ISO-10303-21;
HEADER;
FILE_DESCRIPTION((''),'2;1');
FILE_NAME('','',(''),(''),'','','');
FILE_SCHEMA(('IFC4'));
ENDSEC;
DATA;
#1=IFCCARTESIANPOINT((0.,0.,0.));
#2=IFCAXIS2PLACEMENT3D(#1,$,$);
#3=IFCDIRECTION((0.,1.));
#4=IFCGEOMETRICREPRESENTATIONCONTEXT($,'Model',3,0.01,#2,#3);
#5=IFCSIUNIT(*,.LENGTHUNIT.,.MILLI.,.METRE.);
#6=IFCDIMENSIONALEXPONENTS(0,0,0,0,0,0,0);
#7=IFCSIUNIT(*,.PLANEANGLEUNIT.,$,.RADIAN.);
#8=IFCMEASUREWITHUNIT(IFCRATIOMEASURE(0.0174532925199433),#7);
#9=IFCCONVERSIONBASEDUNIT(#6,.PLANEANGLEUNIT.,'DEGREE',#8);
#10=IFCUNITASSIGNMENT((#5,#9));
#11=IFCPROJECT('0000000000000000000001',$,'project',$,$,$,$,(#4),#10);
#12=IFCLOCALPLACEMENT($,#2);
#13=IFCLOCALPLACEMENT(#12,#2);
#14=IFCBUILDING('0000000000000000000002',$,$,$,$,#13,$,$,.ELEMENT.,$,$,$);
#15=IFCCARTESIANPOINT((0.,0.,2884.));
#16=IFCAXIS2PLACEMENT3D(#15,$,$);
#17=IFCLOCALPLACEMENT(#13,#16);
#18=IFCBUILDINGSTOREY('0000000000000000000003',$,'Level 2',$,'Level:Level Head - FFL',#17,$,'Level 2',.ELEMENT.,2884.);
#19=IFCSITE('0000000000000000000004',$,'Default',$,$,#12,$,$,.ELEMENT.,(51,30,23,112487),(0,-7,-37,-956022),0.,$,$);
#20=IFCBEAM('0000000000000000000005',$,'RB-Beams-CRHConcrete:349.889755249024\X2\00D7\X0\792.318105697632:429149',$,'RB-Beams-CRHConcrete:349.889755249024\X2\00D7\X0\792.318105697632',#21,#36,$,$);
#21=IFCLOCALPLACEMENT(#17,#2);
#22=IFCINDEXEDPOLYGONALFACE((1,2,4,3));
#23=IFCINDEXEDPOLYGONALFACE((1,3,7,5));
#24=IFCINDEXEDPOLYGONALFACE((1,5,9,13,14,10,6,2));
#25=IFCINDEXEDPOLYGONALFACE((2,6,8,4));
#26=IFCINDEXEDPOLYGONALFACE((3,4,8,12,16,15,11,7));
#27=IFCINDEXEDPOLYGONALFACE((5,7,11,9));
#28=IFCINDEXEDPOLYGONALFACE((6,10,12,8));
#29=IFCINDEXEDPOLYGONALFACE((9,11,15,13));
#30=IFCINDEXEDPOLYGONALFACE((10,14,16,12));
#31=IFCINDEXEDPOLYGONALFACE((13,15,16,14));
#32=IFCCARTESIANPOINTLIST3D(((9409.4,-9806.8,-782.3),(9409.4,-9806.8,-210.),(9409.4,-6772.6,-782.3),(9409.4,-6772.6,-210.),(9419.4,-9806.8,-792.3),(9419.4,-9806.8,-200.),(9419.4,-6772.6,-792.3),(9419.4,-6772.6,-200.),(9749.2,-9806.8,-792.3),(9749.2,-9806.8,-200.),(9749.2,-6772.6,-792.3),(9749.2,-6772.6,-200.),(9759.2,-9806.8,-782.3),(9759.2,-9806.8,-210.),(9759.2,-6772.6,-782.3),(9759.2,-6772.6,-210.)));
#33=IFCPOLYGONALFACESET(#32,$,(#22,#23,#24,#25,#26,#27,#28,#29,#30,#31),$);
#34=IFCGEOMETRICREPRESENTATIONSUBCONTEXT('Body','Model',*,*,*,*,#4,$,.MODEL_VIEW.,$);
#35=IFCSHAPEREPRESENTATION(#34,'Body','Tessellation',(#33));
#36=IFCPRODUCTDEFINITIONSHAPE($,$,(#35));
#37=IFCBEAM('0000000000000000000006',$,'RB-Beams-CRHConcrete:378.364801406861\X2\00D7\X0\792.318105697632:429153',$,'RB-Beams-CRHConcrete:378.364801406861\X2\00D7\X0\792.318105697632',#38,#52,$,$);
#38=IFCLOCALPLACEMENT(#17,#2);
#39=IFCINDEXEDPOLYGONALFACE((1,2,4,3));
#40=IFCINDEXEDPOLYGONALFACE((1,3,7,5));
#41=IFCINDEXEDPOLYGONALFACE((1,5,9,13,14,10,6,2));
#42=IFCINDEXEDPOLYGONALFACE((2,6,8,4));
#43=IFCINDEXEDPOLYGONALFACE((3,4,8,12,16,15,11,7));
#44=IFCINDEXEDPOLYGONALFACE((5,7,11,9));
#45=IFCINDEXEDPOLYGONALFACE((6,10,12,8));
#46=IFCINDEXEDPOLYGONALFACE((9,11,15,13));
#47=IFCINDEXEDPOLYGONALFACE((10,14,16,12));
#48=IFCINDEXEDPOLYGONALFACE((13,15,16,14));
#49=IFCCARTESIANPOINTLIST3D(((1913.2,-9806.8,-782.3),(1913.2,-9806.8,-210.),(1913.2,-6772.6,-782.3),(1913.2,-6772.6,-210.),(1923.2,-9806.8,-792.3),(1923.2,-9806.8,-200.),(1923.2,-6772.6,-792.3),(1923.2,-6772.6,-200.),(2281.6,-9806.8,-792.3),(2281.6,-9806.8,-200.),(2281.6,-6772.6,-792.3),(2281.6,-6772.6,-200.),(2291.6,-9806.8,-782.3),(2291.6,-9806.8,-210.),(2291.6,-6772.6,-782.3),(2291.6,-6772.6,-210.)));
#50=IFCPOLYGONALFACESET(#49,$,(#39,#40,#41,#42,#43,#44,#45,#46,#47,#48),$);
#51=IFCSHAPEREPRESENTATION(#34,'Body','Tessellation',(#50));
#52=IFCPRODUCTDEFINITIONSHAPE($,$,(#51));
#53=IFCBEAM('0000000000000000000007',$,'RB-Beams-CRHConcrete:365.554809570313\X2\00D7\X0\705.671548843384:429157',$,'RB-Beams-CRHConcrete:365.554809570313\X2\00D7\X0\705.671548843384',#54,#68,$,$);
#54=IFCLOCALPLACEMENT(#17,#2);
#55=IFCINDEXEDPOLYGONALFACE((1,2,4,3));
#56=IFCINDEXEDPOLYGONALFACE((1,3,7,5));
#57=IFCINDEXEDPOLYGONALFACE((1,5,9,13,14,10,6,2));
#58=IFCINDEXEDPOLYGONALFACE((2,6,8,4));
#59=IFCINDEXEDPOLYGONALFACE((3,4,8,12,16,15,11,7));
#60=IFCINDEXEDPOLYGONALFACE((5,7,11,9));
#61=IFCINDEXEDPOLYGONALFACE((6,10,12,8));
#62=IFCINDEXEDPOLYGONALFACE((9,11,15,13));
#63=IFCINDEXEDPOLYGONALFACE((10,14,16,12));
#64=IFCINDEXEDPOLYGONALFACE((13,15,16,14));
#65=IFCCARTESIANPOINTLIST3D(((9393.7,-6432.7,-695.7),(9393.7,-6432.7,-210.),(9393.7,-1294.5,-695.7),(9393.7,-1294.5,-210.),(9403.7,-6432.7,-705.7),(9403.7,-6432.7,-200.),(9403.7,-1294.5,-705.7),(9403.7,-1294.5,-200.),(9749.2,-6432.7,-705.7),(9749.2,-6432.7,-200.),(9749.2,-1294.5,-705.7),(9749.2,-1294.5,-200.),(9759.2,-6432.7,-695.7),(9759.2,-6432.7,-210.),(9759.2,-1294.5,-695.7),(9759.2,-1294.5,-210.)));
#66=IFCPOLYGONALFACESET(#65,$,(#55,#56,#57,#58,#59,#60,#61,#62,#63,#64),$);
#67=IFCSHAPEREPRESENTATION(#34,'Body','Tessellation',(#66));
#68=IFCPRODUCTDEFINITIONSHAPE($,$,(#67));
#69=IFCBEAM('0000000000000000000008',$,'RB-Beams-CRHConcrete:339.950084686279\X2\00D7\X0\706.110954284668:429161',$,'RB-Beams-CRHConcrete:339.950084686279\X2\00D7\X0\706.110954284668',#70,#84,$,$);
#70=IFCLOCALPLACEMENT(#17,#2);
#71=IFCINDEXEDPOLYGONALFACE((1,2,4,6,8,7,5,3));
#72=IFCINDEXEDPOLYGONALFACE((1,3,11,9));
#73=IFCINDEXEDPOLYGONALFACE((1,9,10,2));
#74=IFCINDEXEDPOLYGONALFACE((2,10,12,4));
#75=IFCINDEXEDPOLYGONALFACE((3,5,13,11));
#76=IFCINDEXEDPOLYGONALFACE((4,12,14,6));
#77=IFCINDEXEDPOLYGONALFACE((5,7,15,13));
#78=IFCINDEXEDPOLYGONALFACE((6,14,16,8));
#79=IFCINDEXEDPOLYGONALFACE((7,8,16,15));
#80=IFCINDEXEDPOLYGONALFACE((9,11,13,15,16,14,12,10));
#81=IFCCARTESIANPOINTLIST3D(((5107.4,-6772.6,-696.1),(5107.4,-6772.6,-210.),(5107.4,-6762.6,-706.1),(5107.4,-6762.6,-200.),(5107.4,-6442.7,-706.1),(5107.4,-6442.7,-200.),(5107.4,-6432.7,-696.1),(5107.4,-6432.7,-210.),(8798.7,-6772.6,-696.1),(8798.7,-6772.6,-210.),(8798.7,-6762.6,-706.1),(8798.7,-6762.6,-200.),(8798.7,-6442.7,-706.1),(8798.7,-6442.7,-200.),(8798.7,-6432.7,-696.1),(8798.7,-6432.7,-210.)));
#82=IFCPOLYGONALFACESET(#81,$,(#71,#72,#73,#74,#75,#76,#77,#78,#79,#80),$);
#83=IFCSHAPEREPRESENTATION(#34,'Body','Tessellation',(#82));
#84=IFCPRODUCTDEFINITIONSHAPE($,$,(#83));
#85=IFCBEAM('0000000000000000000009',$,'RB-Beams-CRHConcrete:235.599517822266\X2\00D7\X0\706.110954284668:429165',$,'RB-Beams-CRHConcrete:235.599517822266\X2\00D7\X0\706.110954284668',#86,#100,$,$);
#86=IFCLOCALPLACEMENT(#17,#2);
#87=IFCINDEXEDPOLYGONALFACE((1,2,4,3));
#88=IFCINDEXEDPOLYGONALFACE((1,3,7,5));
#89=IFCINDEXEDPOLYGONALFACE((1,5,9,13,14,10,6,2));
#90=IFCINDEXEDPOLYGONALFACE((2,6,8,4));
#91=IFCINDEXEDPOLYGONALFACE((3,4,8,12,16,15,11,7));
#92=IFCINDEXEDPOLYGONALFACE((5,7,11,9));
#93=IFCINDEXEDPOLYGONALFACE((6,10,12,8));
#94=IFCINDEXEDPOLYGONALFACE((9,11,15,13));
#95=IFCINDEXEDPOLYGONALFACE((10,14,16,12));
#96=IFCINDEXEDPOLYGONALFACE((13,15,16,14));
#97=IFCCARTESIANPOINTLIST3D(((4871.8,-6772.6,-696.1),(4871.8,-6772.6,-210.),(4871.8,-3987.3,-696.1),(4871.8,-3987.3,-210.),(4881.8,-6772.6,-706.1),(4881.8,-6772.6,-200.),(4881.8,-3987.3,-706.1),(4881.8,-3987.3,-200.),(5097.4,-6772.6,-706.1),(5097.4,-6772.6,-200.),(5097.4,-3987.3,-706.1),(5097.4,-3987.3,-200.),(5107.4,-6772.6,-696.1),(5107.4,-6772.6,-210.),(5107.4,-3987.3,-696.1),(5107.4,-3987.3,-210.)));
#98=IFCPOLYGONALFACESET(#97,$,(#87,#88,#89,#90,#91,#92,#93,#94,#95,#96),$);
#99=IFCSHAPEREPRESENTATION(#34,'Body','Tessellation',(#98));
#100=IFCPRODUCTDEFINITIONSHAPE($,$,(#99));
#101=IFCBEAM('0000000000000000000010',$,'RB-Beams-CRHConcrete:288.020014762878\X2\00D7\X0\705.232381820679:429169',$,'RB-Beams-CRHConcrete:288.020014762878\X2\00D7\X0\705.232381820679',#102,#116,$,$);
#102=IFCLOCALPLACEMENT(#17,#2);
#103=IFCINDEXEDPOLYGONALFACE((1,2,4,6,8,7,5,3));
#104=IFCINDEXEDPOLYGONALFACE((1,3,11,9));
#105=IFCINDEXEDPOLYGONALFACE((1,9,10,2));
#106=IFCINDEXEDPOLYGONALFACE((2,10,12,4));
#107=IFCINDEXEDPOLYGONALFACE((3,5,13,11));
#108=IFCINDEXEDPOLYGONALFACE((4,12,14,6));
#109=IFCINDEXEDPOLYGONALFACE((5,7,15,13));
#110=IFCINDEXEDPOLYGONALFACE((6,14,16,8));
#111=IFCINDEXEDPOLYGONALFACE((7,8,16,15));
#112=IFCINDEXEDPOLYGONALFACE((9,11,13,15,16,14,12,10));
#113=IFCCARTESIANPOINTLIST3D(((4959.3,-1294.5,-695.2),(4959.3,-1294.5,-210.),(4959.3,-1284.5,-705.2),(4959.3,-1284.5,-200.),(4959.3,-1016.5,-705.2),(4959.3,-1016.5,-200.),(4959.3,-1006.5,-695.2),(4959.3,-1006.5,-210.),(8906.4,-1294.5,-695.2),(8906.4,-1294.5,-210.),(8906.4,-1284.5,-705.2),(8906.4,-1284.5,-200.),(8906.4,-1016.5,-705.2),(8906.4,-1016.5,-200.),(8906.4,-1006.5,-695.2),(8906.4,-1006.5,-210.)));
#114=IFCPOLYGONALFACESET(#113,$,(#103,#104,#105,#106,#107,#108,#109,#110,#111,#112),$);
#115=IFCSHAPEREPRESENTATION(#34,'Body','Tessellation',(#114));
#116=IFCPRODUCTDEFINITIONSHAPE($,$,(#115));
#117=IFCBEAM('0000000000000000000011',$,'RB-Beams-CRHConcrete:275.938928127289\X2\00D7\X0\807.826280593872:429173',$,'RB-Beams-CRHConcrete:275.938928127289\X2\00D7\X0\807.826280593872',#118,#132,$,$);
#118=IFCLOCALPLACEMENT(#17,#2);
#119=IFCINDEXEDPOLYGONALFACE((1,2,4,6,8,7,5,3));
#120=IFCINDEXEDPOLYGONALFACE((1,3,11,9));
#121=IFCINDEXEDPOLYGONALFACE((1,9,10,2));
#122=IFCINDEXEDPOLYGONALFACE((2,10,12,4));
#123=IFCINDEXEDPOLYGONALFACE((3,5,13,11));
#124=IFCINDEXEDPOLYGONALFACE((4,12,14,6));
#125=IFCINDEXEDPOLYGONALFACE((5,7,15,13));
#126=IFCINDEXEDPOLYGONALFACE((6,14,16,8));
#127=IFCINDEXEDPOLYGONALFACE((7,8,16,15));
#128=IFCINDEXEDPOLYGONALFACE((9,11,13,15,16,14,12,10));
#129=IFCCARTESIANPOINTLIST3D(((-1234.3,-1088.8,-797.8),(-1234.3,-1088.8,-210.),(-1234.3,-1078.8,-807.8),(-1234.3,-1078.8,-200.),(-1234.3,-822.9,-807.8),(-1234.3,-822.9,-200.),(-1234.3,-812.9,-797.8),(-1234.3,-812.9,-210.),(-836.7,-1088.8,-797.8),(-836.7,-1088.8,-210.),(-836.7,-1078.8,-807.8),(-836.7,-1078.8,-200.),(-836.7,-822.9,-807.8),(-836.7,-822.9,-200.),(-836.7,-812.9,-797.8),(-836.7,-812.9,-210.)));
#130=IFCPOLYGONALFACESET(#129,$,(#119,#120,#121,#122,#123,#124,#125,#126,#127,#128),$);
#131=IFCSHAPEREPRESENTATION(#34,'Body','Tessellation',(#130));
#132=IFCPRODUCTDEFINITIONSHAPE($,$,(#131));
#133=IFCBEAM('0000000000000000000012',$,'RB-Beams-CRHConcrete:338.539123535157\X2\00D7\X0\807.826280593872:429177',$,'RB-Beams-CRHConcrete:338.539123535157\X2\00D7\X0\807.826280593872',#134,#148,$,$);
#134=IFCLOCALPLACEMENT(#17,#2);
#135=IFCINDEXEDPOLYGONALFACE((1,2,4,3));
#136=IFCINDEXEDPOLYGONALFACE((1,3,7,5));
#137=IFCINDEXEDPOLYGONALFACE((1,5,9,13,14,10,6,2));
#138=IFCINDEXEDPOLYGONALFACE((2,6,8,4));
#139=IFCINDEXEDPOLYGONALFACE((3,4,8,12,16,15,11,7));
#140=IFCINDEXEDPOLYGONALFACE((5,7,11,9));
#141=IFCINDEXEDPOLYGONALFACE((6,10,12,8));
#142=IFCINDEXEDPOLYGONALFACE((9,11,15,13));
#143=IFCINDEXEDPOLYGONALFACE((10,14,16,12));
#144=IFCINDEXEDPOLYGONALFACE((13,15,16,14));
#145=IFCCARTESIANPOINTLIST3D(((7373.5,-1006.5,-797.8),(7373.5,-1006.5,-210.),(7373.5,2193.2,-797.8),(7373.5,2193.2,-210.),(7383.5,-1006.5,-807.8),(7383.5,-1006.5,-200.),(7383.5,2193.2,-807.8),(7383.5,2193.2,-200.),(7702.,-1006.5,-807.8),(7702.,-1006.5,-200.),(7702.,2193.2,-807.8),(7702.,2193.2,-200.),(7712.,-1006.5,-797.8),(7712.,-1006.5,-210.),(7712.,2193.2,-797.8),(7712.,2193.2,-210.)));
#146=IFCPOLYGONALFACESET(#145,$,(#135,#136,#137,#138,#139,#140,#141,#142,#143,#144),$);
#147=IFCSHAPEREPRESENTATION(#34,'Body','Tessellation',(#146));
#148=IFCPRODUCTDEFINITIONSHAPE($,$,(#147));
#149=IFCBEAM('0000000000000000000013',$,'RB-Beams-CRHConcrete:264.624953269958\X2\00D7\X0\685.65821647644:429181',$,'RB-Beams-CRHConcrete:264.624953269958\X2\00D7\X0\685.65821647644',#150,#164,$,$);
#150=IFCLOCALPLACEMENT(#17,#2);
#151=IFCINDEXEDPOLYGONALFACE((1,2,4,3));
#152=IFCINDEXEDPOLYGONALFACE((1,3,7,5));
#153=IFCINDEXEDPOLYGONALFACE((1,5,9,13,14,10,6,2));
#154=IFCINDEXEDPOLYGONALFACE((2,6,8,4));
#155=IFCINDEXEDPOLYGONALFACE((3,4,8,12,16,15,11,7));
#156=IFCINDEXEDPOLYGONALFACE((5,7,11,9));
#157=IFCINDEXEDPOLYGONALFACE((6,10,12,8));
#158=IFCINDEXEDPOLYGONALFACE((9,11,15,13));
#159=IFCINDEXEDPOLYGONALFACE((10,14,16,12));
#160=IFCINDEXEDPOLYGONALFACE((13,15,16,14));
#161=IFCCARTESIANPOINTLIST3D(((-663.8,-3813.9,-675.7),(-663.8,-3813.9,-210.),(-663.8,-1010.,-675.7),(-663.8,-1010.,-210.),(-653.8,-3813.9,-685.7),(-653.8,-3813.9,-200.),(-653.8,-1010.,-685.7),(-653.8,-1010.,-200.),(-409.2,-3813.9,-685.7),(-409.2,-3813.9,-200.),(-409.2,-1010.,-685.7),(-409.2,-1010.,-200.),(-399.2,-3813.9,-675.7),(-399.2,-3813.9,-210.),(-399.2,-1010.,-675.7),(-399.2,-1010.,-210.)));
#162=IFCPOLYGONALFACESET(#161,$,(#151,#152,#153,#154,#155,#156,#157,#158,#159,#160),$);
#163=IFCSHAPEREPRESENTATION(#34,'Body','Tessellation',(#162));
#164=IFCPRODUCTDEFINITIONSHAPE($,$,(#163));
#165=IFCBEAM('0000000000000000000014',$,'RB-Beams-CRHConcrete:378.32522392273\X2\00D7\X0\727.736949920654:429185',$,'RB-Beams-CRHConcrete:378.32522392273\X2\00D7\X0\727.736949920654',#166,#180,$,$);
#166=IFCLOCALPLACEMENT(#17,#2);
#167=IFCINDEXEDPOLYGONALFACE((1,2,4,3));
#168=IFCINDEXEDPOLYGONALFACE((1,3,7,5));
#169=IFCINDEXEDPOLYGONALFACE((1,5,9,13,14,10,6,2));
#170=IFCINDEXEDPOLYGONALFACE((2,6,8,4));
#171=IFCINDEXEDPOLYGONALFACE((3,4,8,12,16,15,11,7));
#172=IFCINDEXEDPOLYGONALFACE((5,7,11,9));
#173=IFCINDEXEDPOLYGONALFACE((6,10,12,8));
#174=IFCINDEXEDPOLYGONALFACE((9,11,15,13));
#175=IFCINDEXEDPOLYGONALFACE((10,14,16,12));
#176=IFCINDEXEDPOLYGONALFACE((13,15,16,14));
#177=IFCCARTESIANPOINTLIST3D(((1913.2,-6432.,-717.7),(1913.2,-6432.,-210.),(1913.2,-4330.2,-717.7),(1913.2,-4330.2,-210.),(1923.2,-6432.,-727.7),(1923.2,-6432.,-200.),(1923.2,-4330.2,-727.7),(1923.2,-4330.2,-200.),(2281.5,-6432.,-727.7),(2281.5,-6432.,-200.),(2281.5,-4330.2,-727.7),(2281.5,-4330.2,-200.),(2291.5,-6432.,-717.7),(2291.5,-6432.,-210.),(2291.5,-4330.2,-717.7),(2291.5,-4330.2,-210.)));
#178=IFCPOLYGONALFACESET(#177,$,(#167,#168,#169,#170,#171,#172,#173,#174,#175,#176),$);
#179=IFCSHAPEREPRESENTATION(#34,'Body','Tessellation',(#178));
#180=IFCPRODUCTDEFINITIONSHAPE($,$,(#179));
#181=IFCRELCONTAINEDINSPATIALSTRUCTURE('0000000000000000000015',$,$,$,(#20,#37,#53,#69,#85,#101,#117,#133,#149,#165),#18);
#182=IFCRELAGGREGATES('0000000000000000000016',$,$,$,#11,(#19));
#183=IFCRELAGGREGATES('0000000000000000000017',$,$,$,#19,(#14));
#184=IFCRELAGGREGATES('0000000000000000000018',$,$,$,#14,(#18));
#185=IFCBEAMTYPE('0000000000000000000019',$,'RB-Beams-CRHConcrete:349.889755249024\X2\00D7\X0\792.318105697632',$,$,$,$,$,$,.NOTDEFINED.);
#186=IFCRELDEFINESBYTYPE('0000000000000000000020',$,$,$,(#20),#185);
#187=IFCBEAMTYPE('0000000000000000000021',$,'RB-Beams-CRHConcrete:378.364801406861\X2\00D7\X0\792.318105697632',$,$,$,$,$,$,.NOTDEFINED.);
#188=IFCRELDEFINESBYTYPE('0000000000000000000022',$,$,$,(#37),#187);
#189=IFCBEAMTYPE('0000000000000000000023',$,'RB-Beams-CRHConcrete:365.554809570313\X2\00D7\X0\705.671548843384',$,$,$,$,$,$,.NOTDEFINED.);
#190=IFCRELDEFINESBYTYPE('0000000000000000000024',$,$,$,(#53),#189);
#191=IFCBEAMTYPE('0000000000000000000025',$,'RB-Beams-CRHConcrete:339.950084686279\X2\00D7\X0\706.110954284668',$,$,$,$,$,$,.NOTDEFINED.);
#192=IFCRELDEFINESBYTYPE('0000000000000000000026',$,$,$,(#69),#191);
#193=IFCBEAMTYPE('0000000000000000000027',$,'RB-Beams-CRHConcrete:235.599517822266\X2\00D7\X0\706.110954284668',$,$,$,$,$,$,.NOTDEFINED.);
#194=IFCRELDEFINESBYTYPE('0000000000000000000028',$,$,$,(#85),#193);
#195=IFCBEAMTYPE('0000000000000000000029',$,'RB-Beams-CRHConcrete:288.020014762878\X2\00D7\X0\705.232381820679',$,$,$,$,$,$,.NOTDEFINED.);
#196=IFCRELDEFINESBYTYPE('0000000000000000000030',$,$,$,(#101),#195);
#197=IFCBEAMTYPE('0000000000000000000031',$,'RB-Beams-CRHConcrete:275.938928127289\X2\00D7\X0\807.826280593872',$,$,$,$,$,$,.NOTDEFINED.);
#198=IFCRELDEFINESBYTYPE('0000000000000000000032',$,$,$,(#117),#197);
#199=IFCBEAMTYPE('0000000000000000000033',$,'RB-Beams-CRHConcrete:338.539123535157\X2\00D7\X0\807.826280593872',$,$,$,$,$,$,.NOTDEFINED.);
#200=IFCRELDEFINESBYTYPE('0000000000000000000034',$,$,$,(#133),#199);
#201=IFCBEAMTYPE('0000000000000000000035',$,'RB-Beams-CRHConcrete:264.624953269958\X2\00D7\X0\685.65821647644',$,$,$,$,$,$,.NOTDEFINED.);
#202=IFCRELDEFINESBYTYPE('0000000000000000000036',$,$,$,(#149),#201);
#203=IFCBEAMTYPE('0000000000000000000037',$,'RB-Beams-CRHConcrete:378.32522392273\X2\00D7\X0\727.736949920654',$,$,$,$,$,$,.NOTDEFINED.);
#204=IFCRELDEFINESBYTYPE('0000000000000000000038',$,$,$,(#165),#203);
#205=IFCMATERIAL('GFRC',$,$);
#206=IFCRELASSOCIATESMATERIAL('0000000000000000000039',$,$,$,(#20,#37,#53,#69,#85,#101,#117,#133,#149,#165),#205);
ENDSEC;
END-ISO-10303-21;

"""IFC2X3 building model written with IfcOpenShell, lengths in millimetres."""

from ifc_helpers import new_model, entity, si_unit, converted_unit, direction, frame, origin, place, context, subcontext, project, spatial, polyline, outline, extrude, material, type_object, element, save


model = new_model("IFC2X3")

# Units and contexts
model_context = context("Model", 3, precision=0.01, world=origin(), true_north=direction((0.0, 1.0)))
body_context = subcontext(model_context, "Body", "Model", "MODEL_VIEW")
ifc_project = project(units=[si_unit("LENGTHUNIT", "METRE", prefix="MILLI"), converted_unit("PLANEANGLEUNIT", "DEGREE", entity("IfcRatioMeasure", 0.0174532925199433), si_unit("PLANEANGLEUNIT", "RADIAN"), dimensions=[0, 0, 0, 0, 0, 0, 0])], contexts=[model_context])

# Site, building, storey
site_placement = place(None, origin())
site = spatial("IfcSite", under=ifc_project, at=site_placement, Name="Default", CompositionType="ELEMENT", RefLatitude=(51, 30, 23, 112487), RefLongitude=(0, -7, -37, -956022), RefElevation=0.0)
building_placement = place(site_placement, origin())
building = spatial("IfcBuilding", under=site, at=building_placement, CompositionType="ELEMENT")
storey_placement = place(building_placement, frame((0.0, 0.0, 2884.0)))
storey = spatial("IfcBuildingStorey", under=building, at=storey_placement, Name="Level 2", ObjectType="Level:Level Head - FFL", LongName="Level 2", CompositionType="ELEMENT", Elevation=2884.0)

# Beams
ifc_material_1 = material(Name="GFRC")
beam_type_1 = type_object("IfcBeamType", Name="RB-Beams-CRHConcrete:349.889755249024×792.318105697632", PredefinedType="NOTDEFINED")
beam_1_placement = place(storey_placement, frame((9584.3, -9806.8, -200.0), z_axis=(0.0, 0.0, 1.0), x_axis=(0.0, 1.0, 0.0)))
element("IfcBeam", 1, at=beam_1_placement, inside=storey, type_object=beam_type_1, material=ifc_material_1, Name="RB-Beams-CRHConcrete:349.889755249024×792.318105697632:429149", ObjectType="RB-Beams-CRHConcrete:349.889755249024×792.318105697632", context=body_context, shape_type="SweptSolid", body=[
    extrude(outline(polyline([(-286.2, -174.9), (286.2, -174.9), (296.2, -164.9), (296.2, 164.9), (286.2, 174.9), (-286.2, 174.9), (-296.2, 164.9), (-296.2, -164.9), (-286.2, -174.9)])), frame((0.0, 0.0, -296.2), z_axis=(1.0, 0.0, 0.0), x_axis=(0.0, 0.0, -1.0)), (0.0, 0.0, 1.0), 3034.2),
])
beam_type_2 = type_object("IfcBeamType", Name="RB-Beams-CRHConcrete:378.364801406861×792.318105697632", PredefinedType="NOTDEFINED")
beam_2_placement = place(storey_placement, frame((2102.4, -9806.8, -200.0), z_axis=(0.0, 0.0, 1.0), x_axis=(0.0, 1.0, 0.0)))
element("IfcBeam", 2, at=beam_2_placement, inside=storey, type_object=beam_type_2, material=ifc_material_1, Name="RB-Beams-CRHConcrete:378.364801406861×792.318105697632:429153", ObjectType="RB-Beams-CRHConcrete:378.364801406861×792.318105697632", context=body_context, shape_type="SweptSolid", body=[
    extrude(outline(polyline([(-286.2, -189.2), (286.2, -189.2), (296.2, -179.2), (296.2, 179.2), (286.2, 189.2), (-286.2, 189.2), (-296.2, 179.2), (-296.2, -179.2), (-286.2, -189.2)])), frame((0.0, 0.0, -296.2), z_axis=(1.0, 0.0, 0.0), x_axis=(0.0, 0.0, -1.0)), (0.0, 0.0, 1.0), 3034.2),
])
beam_type_3 = type_object("IfcBeamType", Name="RB-Beams-CRHConcrete:365.554809570313×705.671548843384", PredefinedType="NOTDEFINED")
beam_3_placement = place(storey_placement, frame((9576.5, -6432.7, -200.0), z_axis=(0.0, 0.0, 1.0), x_axis=(0.0, 1.0, 0.0)))
element("IfcBeam", 3, at=beam_3_placement, inside=storey, type_object=beam_type_3, material=ifc_material_1, Name="RB-Beams-CRHConcrete:365.554809570313×705.671548843384:429157", ObjectType="RB-Beams-CRHConcrete:365.554809570313×705.671548843384", context=body_context, shape_type="SweptSolid", body=[
    extrude(outline(polyline([(-242.8, -182.8), (242.8, -182.8), (252.8, -172.8), (252.8, 172.8), (242.8, 182.8), (-242.8, 182.8), (-252.8, 172.8), (-252.8, -172.8), (-242.8, -182.8)])), frame((0.0, 0.0, -252.8), z_axis=(1.0, 0.0, 0.0), x_axis=(0.0, 0.0, -1.0)), (0.0, 0.0, 1.0), 5138.2),
])
beam_type_4 = type_object("IfcBeamType", Name="RB-Beams-CRHConcrete:339.950084686279×706.110954284668", PredefinedType="NOTDEFINED")
beam_4_placement = place(storey_placement, frame((5107.4, -6602.7, -200.0)))
element("IfcBeam", 4, at=beam_4_placement, inside=storey, type_object=beam_type_4, material=ifc_material_1, Name="RB-Beams-CRHConcrete:339.950084686279×706.110954284668:429161", ObjectType="RB-Beams-CRHConcrete:339.950084686279×706.110954284668", context=body_context, shape_type="SweptSolid", body=[
    extrude(outline(polyline([(-243.1, -170.0), (243.1, -170.0), (253.1, -160.0), (253.1, 160.0), (243.1, 170.0), (-243.1, 170.0), (-253.1, 160.0), (-253.1, -160.0), (-243.1, -170.0)])), frame((0.0, 0.0, -253.1), z_axis=(1.0, 0.0, 0.0), x_axis=(0.0, 0.0, -1.0)), (0.0, 0.0, 1.0), 3691.3),
])
beam_type_5 = type_object("IfcBeamType", Name="RB-Beams-CRHConcrete:235.599517822266×706.110954284668", PredefinedType="NOTDEFINED")
beam_5_placement = place(storey_placement, frame((4989.6, -6772.6, -200.0), z_axis=(0.0, 0.0, 1.0), x_axis=(0.0, 1.0, 0.0)))
element("IfcBeam", 5, at=beam_5_placement, inside=storey, type_object=beam_type_5, material=ifc_material_1, Name="RB-Beams-CRHConcrete:235.599517822266×706.110954284668:429165", ObjectType="RB-Beams-CRHConcrete:235.599517822266×706.110954284668", context=body_context, shape_type="SweptSolid", body=[
    extrude(outline(polyline([(-243.1, -117.8), (243.1, -117.8), (253.1, -107.8), (253.1, 107.8), (243.1, 117.8), (-243.1, 117.8), (-253.1, 107.8), (-253.1, -107.8), (-243.1, -117.8)])), frame((0.0, 0.0, -253.1), z_axis=(1.0, 0.0, 0.0), x_axis=(0.0, 0.0, -1.0)), (0.0, 0.0, 1.0), 2785.4),
])
beam_type_6 = type_object("IfcBeamType", Name="RB-Beams-CRHConcrete:288.020014762878×705.232381820679", PredefinedType="NOTDEFINED")
beam_6_placement = place(storey_placement, frame((4959.3, -1150.5, -200.0)))
element("IfcBeam", 6, at=beam_6_placement, inside=storey, type_object=beam_type_6, material=ifc_material_1, Name="RB-Beams-CRHConcrete:288.020014762878×705.232381820679:429169", ObjectType="RB-Beams-CRHConcrete:288.020014762878×705.232381820679", context=body_context, shape_type="SweptSolid", body=[
    extrude(outline(polyline([(-242.6, -144.0), (242.6, -144.0), (252.6, -134.0), (252.6, 134.0), (242.6, 144.0), (-242.6, 144.0), (-252.6, 134.0), (-252.6, -134.0), (-242.6, -144.0)])), frame((0.0, 0.0, -252.6), z_axis=(1.0, 0.0, 0.0), x_axis=(0.0, 0.0, -1.0)), (0.0, 0.0, 1.0), 3947.1),
])
beam_type_7 = type_object("IfcBeamType", Name="RB-Beams-CRHConcrete:275.938928127289×807.826280593872", PredefinedType="NOTDEFINED")
beam_7_placement = place(storey_placement, frame((-1234.3, -950.8, -200.0)))
element("IfcBeam", 7, at=beam_7_placement, inside=storey, type_object=beam_type_7, material=ifc_material_1, Name="RB-Beams-CRHConcrete:275.938928127289×807.826280593872:429173", ObjectType="RB-Beams-CRHConcrete:275.938928127289×807.826280593872", context=body_context, shape_type="SweptSolid", body=[
    extrude(outline(polyline([(-293.9, -138.0), (293.9, -138.0), (303.9, -128.0), (303.9, 128.0), (293.9, 138.0), (-293.9, 138.0), (-303.9, 128.0), (-303.9, -128.0), (-293.9, -138.0)])), frame((0.0, 0.0, -303.9), z_axis=(1.0, 0.0, 0.0), x_axis=(0.0, 0.0, -1.0)), (0.0, 0.0, 1.0), 397.6),
])
beam_type_8 = type_object("IfcBeamType", Name="RB-Beams-CRHConcrete:338.539123535157×807.826280593872", PredefinedType="NOTDEFINED")
beam_8_placement = place(storey_placement, frame((7542.7, -1006.5, -200.0), z_axis=(0.0, 0.0, 1.0), x_axis=(0.0, 1.0, 0.0)))
element("IfcBeam", 8, at=beam_8_placement, inside=storey, type_object=beam_type_8, material=ifc_material_1, Name="RB-Beams-CRHConcrete:338.539123535157×807.826280593872:429177", ObjectType="RB-Beams-CRHConcrete:338.539123535157×807.826280593872", context=body_context, shape_type="SweptSolid", body=[
    extrude(outline(polyline([(-293.9, -169.3), (293.9, -169.3), (303.9, -159.3), (303.9, 159.3), (293.9, 169.3), (-293.9, 169.3), (-303.9, 159.3), (-303.9, -159.3), (-293.9, -169.3)])), frame((0.0, 0.0, -303.9), z_axis=(1.0, 0.0, 0.0), x_axis=(0.0, 0.0, -1.0)), (0.0, 0.0, 1.0), 3199.6),
])
beam_type_9 = type_object("IfcBeamType", Name="RB-Beams-CRHConcrete:264.624953269958×685.65821647644", PredefinedType="NOTDEFINED")
beam_9_placement = place(storey_placement, frame((-531.5, -3813.9, -200.0), z_axis=(0.0, 0.0, 1.0), x_axis=(0.0, 1.0, 0.0)))
element("IfcBeam", 9, at=beam_9_placement, inside=storey, type_object=beam_type_9, material=ifc_material_1, Name="RB-Beams-CRHConcrete:264.624953269958×685.65821647644:429181", ObjectType="RB-Beams-CRHConcrete:264.624953269958×685.65821647644", context=body_context, shape_type="SweptSolid", body=[
    extrude(outline(polyline([(-232.8, -132.3), (232.8, -132.3), (242.8, -122.3), (242.8, 122.3), (232.8, 132.3), (-232.8, 132.3), (-242.8, 122.3), (-242.8, -122.3), (-232.8, -132.3)])), frame((0.0, 0.0, -242.8), z_axis=(1.0, 0.0, 0.0), x_axis=(0.0, 0.0, -1.0)), (0.0, 0.0, 1.0), 2803.9),
])
beam_type_10 = type_object("IfcBeamType", Name="RB-Beams-CRHConcrete:378.32522392273×727.736949920654", PredefinedType="NOTDEFINED")
beam_10_placement = place(storey_placement, frame((2102.4, -6432.0, -200.0), z_axis=(0.0, 0.0, 1.0), x_axis=(0.0, 1.0, 0.0)))
element("IfcBeam", 10, at=beam_10_placement, inside=storey, type_object=beam_type_10, material=ifc_material_1, Name="RB-Beams-CRHConcrete:378.32522392273×727.736949920654:429185", ObjectType="RB-Beams-CRHConcrete:378.32522392273×727.736949920654", context=body_context, shape_type="SweptSolid", body=[
    extrude(outline(polyline([(-253.9, -189.2), (253.9, -189.2), (263.9, -179.2), (263.9, 179.2), (253.9, 189.2), (-253.9, 189.2), (-263.9, 179.2), (-263.9, -179.2), (-253.9, -189.2)])), frame((0.0, 0.0, -263.9), z_axis=(1.0, 0.0, 0.0), x_axis=(0.0, 0.0, -1.0)), (0.0, 0.0, 1.0), 2101.8),
])

save(model, "model.ifc")
